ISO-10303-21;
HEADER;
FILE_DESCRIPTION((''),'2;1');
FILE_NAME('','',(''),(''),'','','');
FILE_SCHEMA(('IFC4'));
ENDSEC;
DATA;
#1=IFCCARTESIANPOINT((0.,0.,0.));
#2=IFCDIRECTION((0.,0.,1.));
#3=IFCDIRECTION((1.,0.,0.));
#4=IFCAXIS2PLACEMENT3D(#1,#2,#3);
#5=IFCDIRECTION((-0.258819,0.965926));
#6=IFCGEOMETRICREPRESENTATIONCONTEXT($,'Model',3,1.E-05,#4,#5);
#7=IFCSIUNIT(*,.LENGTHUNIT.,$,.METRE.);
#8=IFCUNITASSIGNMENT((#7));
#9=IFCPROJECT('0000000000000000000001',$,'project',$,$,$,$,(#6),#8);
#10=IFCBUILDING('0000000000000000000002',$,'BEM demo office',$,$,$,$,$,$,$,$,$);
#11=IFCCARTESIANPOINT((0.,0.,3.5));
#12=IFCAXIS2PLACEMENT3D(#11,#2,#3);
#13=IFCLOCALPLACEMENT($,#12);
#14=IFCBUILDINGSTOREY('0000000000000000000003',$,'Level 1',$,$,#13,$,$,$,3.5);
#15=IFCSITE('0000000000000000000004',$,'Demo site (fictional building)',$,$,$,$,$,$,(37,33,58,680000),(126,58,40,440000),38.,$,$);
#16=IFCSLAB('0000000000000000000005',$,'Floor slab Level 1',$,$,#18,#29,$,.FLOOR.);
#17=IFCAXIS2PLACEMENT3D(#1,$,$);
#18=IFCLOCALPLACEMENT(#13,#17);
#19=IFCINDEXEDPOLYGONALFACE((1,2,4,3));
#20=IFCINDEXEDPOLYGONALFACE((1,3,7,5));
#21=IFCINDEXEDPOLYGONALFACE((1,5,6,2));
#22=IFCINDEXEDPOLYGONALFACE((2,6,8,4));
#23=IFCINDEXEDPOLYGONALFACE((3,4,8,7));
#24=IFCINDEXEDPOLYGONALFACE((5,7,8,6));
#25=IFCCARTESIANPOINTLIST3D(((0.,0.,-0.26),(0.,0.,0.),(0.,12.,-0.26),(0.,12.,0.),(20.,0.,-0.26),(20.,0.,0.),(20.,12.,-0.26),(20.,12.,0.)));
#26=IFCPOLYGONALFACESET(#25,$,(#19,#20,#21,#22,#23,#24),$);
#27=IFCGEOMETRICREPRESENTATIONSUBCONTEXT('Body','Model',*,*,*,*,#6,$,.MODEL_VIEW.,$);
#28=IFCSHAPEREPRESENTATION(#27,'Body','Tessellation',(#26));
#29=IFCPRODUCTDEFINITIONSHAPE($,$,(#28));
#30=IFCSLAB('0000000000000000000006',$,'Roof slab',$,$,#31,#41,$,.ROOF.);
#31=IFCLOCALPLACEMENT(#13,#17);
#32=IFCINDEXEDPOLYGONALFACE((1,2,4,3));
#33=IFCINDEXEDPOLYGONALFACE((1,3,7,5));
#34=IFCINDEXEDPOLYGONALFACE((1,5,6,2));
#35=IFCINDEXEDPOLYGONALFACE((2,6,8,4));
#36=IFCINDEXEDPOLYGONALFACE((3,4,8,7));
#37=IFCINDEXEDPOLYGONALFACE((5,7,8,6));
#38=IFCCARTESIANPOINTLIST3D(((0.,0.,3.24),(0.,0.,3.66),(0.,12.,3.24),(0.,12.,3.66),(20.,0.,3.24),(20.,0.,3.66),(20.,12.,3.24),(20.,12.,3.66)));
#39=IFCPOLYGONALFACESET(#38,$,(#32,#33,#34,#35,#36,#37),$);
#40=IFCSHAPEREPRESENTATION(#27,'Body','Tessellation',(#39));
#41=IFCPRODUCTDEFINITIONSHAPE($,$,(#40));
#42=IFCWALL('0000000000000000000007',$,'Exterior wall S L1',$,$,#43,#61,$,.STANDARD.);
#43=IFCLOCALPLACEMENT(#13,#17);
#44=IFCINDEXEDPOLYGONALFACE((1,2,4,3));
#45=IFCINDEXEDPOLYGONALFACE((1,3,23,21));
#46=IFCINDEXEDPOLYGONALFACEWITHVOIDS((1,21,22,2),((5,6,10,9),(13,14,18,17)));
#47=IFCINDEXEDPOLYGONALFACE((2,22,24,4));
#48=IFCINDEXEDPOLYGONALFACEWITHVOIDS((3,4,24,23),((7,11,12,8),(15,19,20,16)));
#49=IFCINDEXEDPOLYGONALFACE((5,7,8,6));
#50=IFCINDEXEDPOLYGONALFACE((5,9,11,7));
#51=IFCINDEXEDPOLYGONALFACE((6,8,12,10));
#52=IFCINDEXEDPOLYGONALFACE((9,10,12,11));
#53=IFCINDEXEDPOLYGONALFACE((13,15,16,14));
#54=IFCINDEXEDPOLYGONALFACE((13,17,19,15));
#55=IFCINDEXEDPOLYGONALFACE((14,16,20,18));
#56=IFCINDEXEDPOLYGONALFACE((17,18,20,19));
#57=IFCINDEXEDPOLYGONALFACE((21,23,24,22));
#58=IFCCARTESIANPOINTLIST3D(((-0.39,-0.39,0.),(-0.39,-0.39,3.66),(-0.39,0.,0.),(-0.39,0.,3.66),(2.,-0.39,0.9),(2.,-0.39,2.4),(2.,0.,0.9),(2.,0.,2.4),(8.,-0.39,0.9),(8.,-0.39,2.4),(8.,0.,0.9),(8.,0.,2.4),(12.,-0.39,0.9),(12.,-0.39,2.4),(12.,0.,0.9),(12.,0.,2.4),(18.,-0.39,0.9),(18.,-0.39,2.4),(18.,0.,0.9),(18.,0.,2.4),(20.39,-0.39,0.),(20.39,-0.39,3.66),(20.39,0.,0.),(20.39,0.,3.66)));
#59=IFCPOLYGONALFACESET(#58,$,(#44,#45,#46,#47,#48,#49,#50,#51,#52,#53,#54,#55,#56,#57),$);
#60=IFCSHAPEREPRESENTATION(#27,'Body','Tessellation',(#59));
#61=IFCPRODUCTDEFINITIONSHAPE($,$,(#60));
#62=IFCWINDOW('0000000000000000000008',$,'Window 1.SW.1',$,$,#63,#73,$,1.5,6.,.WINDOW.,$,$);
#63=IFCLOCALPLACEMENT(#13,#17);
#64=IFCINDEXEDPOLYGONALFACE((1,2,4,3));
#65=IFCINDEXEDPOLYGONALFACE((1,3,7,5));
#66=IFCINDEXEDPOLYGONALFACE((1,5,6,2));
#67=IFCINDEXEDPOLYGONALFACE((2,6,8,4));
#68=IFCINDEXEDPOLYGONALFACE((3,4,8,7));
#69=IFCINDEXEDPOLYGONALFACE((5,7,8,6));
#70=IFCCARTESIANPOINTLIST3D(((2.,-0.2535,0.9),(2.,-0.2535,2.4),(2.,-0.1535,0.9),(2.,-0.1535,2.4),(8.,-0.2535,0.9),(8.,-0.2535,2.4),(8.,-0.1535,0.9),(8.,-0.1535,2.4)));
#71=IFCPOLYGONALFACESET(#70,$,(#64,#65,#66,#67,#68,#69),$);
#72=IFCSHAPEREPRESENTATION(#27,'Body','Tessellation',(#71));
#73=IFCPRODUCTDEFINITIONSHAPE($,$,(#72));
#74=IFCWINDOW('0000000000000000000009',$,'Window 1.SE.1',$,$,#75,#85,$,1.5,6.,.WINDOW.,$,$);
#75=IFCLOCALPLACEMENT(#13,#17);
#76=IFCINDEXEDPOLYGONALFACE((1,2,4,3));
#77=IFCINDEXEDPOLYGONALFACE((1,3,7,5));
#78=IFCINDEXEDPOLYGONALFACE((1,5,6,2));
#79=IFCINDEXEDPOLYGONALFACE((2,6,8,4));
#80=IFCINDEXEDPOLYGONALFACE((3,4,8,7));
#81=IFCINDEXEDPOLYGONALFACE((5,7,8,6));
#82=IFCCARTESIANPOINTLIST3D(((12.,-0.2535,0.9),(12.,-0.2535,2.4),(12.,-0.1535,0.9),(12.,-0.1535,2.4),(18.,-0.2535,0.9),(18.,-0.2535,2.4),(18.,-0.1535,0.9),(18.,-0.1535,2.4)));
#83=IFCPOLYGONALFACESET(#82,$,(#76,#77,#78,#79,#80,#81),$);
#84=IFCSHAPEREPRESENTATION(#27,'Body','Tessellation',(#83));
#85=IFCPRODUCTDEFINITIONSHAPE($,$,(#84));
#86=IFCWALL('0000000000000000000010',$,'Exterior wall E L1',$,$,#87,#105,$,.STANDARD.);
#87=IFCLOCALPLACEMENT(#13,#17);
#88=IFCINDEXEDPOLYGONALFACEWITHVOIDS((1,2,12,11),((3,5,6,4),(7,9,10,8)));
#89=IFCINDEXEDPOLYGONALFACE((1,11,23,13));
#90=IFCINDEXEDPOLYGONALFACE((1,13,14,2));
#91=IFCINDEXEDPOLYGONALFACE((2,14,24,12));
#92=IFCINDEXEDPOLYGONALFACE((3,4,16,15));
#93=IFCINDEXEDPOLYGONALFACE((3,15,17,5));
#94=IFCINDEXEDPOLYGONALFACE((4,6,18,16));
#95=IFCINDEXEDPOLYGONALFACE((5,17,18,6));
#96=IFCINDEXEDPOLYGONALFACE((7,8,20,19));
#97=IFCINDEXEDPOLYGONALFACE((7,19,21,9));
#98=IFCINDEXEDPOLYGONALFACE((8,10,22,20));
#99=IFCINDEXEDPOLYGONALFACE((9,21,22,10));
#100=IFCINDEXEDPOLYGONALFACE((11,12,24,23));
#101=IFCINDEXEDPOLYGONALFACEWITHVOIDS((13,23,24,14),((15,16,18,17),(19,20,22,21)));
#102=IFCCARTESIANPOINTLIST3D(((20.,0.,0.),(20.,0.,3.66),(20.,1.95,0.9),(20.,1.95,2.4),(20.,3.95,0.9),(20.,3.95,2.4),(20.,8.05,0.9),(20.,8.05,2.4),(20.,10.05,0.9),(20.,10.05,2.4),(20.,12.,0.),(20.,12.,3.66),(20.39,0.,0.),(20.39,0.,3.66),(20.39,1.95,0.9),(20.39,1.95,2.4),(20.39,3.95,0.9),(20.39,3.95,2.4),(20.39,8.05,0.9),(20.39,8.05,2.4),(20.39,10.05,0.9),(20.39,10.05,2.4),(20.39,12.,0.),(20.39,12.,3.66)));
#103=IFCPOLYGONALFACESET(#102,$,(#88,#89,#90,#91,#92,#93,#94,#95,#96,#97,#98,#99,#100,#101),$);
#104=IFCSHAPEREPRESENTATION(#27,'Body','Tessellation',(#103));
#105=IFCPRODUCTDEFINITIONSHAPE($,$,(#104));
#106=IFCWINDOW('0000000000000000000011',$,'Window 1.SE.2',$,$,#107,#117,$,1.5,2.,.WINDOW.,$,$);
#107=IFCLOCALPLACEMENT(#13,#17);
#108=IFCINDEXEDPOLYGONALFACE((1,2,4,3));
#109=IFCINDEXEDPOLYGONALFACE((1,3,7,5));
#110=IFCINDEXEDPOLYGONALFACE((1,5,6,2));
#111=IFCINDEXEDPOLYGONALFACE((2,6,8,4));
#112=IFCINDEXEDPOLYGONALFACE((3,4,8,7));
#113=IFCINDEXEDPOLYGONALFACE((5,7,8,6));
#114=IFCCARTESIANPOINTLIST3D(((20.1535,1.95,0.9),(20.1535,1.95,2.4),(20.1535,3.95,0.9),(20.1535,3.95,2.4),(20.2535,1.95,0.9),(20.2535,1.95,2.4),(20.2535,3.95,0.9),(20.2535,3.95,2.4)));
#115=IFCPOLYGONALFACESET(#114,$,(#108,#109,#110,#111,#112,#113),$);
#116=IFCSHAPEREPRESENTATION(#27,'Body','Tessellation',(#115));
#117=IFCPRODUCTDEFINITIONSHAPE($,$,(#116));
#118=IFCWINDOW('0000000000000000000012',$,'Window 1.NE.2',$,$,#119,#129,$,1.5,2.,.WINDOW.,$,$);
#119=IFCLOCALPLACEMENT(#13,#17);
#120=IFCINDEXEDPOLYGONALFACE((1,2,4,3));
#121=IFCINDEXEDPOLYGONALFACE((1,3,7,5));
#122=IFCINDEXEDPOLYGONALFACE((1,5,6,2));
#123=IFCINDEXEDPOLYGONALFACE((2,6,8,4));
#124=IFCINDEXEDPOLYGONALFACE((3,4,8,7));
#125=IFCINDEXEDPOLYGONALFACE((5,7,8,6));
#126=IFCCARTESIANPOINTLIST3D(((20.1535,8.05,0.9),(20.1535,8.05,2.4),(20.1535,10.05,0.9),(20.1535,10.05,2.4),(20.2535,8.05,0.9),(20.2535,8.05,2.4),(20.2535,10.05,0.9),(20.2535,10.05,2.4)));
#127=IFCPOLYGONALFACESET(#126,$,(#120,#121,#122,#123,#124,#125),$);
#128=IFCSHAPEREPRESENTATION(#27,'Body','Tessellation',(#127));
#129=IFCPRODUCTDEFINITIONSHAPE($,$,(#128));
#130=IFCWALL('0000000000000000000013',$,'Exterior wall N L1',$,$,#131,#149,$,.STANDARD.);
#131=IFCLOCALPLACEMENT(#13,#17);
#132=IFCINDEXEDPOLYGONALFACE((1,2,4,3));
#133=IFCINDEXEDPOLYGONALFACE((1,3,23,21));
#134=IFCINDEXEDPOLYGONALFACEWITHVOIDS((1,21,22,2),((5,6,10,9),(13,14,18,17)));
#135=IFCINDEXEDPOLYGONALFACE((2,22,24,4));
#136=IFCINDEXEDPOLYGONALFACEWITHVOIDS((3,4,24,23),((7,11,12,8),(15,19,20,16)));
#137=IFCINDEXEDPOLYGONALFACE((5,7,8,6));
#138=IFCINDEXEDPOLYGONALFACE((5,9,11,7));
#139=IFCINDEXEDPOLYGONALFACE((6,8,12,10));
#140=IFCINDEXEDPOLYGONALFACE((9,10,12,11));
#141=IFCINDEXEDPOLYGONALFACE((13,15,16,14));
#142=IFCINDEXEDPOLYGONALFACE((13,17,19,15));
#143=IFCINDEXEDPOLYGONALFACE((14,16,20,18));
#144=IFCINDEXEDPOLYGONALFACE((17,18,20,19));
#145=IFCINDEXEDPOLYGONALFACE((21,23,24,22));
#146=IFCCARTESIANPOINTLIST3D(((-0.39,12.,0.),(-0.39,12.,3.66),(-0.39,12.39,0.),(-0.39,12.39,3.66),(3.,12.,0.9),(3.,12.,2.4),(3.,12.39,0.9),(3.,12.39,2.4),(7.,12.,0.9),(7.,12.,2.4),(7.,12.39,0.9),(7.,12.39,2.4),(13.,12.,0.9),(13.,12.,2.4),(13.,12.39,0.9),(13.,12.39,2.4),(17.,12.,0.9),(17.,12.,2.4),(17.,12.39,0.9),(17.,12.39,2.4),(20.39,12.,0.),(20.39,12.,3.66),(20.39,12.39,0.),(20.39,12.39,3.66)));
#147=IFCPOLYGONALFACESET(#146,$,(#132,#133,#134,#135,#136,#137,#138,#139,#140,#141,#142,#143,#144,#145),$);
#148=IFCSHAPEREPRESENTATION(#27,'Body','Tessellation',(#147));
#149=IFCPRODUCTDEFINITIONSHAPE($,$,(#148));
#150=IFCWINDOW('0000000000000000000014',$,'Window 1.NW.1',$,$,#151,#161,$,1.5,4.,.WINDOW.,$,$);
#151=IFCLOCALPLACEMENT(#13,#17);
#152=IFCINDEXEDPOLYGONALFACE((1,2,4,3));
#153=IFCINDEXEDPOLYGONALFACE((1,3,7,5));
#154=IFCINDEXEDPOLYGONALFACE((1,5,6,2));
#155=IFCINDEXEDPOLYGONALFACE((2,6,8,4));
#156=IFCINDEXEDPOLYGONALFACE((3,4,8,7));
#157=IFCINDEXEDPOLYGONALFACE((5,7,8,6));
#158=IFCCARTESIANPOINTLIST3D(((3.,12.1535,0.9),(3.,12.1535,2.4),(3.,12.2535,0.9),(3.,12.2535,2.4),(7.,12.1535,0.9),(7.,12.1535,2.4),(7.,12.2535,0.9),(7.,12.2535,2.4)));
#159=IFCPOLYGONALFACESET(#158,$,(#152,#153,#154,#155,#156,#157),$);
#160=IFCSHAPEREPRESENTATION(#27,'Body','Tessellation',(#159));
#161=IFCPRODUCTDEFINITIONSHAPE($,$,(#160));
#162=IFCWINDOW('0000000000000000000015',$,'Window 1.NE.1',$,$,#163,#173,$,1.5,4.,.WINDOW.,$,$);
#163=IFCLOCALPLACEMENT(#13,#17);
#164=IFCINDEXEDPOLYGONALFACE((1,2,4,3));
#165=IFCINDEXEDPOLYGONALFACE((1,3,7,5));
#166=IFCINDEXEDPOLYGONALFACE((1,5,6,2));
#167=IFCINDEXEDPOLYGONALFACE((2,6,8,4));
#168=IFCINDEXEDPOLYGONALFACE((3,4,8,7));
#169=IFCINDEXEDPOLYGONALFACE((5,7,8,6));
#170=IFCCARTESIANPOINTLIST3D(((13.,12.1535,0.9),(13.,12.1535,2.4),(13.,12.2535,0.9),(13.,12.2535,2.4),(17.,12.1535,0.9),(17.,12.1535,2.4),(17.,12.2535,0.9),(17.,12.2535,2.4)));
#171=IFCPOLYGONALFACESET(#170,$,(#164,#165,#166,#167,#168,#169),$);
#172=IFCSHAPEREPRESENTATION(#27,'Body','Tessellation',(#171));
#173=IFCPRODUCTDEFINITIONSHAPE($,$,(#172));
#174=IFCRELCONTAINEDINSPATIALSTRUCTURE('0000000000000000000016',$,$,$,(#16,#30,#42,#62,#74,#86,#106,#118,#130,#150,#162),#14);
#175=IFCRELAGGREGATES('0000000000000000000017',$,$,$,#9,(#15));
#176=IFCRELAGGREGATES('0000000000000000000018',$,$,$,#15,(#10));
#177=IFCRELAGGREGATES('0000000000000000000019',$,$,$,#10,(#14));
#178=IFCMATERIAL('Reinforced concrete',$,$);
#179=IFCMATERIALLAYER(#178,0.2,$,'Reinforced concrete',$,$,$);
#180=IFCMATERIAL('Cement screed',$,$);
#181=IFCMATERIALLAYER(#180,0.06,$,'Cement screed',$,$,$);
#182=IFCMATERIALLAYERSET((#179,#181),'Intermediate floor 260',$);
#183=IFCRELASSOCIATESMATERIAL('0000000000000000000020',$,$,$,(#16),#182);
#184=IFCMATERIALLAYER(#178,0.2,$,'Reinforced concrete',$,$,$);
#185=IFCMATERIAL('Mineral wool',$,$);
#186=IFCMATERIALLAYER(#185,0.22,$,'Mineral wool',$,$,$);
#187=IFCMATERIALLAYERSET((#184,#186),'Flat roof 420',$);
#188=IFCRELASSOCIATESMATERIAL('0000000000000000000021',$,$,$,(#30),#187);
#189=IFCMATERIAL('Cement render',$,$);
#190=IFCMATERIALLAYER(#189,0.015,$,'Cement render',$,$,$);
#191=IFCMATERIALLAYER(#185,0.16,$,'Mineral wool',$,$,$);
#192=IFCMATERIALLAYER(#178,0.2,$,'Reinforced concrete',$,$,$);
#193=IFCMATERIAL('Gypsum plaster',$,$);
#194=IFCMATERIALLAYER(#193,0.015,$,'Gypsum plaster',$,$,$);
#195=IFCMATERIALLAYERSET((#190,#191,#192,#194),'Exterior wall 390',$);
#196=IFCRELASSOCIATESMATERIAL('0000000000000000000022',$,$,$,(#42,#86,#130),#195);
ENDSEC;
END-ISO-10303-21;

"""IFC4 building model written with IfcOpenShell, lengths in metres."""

from ifc_helpers import new_model, si_unit, direction, frame, frame_2d, origin, origin_with_axes, place, context, subcontext, project, spatial, rectangle, extrude, material, layer, layer_set, layer_usage, element, fill, save


model = new_model("IFC4")

# Units and contexts
model_context = context("Model", 3, precision=1e-05, world=origin_with_axes(), true_north=direction((-0.258819, 0.965926)))
body_context = subcontext(model_context, "Body", "Model", "MODEL_VIEW")
ifc_project = project(units=[si_unit("LENGTHUNIT", "METRE")], contexts=[model_context])

# Site, building, storey
site = spatial("IfcSite", under=ifc_project, Name="Demo site (fictional building)", RefLatitude=(37, 33, 58, 680000), RefLongitude=(126, 58, 40, 440000), RefElevation=38.0)
building = spatial("IfcBuilding", under=site, Name="BEM demo office")
storey_placement = place(None, frame((0.0, 0.0, 3.5), z_axis=(0.0, 0.0, 1.0), x_axis=(1.0, 0.0, 0.0)))
storey = spatial("IfcBuildingStorey", under=building, at=storey_placement, Name="Level 1", Elevation=3.5)

# Slabs
ifc_material_1 = material(Name="Reinforced concrete")
ifc_layer_1 = layer(ifc_material_1, 0.2, Name="Reinforced concrete")
ifc_material_2 = material(Name="Cement screed")
ifc_layer_2 = layer(ifc_material_2, 0.06, Name="Cement screed")
ifc_layer_set_1 = layer_set([ifc_layer_1, ifc_layer_2], Name="Intermediate floor 260")
ifc_layer_usage_1 = layer_usage(ifc_layer_set_1, "AXIS3", "POSITIVE", 0.0)
slab_1_placement = place(storey_placement, frame((0.0, 0.0, -0.26), z_axis=(0.0, 0.0, 1.0), x_axis=(1.0, 0.0, 0.0)))
element("IfcSlab", 1, at=slab_1_placement, inside=storey, material=ifc_layer_usage_1, Name="Floor slab Level 1", PredefinedType="FLOOR", context=body_context, shape_type="SweptSolid", body=[
    extrude(rectangle(XDim=20.0, YDim=12.0, at=frame_2d((10.0, 6.0))), origin(), (0.0, 0.0, 1.0), 0.26),
])
ifc_layer_3 = layer(ifc_material_1, 0.2, Name="Reinforced concrete")
ifc_material_3 = material(Name="Mineral wool")
ifc_layer_4 = layer(ifc_material_3, 0.22, Name="Mineral wool")
ifc_layer_set_2 = layer_set([ifc_layer_3, ifc_layer_4], Name="Flat roof 420")
ifc_layer_usage_2 = layer_usage(ifc_layer_set_2, "AXIS3", "POSITIVE", 0.0)
slab_2_placement = place(storey_placement, frame((0.0, 0.0, 3.24), z_axis=(0.0, 0.0, 1.0), x_axis=(1.0, 0.0, 0.0)))
element("IfcSlab", 2, at=slab_2_placement, inside=storey, material=ifc_layer_usage_2, Name="Roof slab", PredefinedType="ROOF", context=body_context, shape_type="SweptSolid", body=[
    extrude(rectangle(XDim=20.0, YDim=12.0, at=frame_2d((10.0, 6.0))), origin(), (0.0, 0.0, 1.0), 0.42),
])

# Walls, openings, windows
ifc_material_4 = material(Name="Cement render")
ifc_layer_5 = layer(ifc_material_4, 0.015, Name="Cement render")
ifc_layer_6 = layer(ifc_material_3, 0.16, Name="Mineral wool")
ifc_layer_7 = layer(ifc_material_1, 0.2, Name="Reinforced concrete")
ifc_material_5 = material(Name="Gypsum plaster")
ifc_layer_8 = layer(ifc_material_5, 0.015, Name="Gypsum plaster")
ifc_layer_set_3 = layer_set([ifc_layer_5, ifc_layer_6, ifc_layer_7, ifc_layer_8], Name="Exterior wall 390")
ifc_layer_usage_3 = layer_usage(ifc_layer_set_3, "AXIS2", "POSITIVE", 0.0)
wall_1_placement = place(storey_placement, frame((-0.39, -0.39, 0.0), z_axis=(0.0, 0.0, 1.0), x_axis=(1.0, 0.0, 0.0)))
wall_1 = element("IfcWall", 3, at=wall_1_placement, inside=storey, material=ifc_layer_usage_3, Name="Exterior wall S L1", PredefinedType="STANDARD", context=body_context, shape_type="SweptSolid", body=[
    extrude(rectangle(XDim=20.78, YDim=0.39, at=frame_2d((10.39, 0.195))), origin(), (0.0, 0.0, 1.0), 3.66),
])
opening_1_placement = place(wall_1_placement, origin())
opening_1 = element("IfcOpeningElement", 4, at=opening_1_placement, cuts=wall_1, PredefinedType="OPENING", context=body_context, shape_type="SweptSolid", body=[
    extrude(rectangle(XDim=6.0, YDim=0.49, at=frame_2d((3.0, 0.245))), frame((2.39, -0.05, 0.9)), (0.0, 0.0, 1.0), 1.5),
])
opening_2_placement = place(wall_1_placement, origin())
opening_2 = element("IfcOpeningElement", 5, at=opening_2_placement, cuts=wall_1, PredefinedType="OPENING", context=body_context, shape_type="SweptSolid", body=[
    extrude(rectangle(XDim=6.0, YDim=0.49, at=frame_2d((3.0, 0.245))), frame((12.39, -0.05, 0.9)), (0.0, 0.0, 1.0), 1.5),
])
window_1_placement = place(opening_1_placement, origin_with_axes())
window_1 = element("IfcWindow", 6, at=window_1_placement, inside=storey, Name="Window 1.SW.1", OverallHeight=1.5, OverallWidth=6.0, PredefinedType="WINDOW", context=body_context, shape_type="SweptSolid", body=[
    extrude(rectangle(XDim=6.0, YDim=0.1, at=frame_2d((3.0, 0.05))), frame((2.39, 0.1365, 0.9)), (0.0, 0.0, 1.0), 1.5),
])
fill(opening_1, window_1)
window_2_placement = place(opening_2_placement, origin_with_axes())
window_2 = element("IfcWindow", 7, at=window_2_placement, inside=storey, Name="Window 1.SE.1", OverallHeight=1.5, OverallWidth=6.0, PredefinedType="WINDOW", context=body_context, shape_type="SweptSolid", body=[
    extrude(rectangle(XDim=6.0, YDim=0.1, at=frame_2d((3.0, 0.05))), frame((12.39, 0.1365, 0.9)), (0.0, 0.0, 1.0), 1.5),
])
fill(opening_2, window_2)
wall_2_placement = place(storey_placement, frame((20.39, 0.0, 0.0), z_axis=(0.0, 0.0, 1.0), x_axis=(0.0, 1.0, 0.0)))
wall_2 = element("IfcWall", 8, at=wall_2_placement, inside=storey, material=ifc_layer_usage_3, Name="Exterior wall E L1", PredefinedType="STANDARD", context=body_context, shape_type="SweptSolid", body=[
    extrude(rectangle(XDim=12.0, YDim=0.39, at=frame_2d((6.0, 0.195))), origin(), (0.0, 0.0, 1.0), 3.66),
])
opening_3_placement = place(wall_2_placement, origin())
opening_3 = element("IfcOpeningElement", 9, at=opening_3_placement, cuts=wall_2, PredefinedType="OPENING", context=body_context, shape_type="SweptSolid", body=[
    extrude(rectangle(XDim=2.0, YDim=0.49, at=frame_2d((1.0, 0.245))), frame((1.95, -0.05, 0.9)), (0.0, 0.0, 1.0), 1.5),
])
opening_4_placement = place(wall_2_placement, origin())
opening_4 = element("IfcOpeningElement", 10, at=opening_4_placement, cuts=wall_2, PredefinedType="OPENING", context=body_context, shape_type="SweptSolid", body=[
    extrude(rectangle(XDim=2.0, YDim=0.49, at=frame_2d((1.0, 0.245))), frame((8.05, -0.05, 0.9)), (0.0, 0.0, 1.0), 1.5),
])
window_3_placement = place(opening_3_placement, origin_with_axes())
window_3 = element("IfcWindow", 11, at=window_3_placement, inside=storey, Name="Window 1.SE.2", OverallHeight=1.5, OverallWidth=2.0, PredefinedType="WINDOW", context=body_context, shape_type="SweptSolid", body=[
    extrude(rectangle(XDim=2.0, YDim=0.1, at=frame_2d((1.0, 0.05))), frame((1.95, 0.1365, 0.9)), (0.0, 0.0, 1.0), 1.5),
])
fill(opening_3, window_3)
window_4_placement = place(opening_4_placement, origin_with_axes())
window_4 = element("IfcWindow", 12, at=window_4_placement, inside=storey, Name="Window 1.NE.2", OverallHeight=1.5, OverallWidth=2.0, PredefinedType="WINDOW", context=body_context, shape_type="SweptSolid", body=[
    extrude(rectangle(XDim=2.0, YDim=0.1, at=frame_2d((1.0, 0.05))), frame((8.05, 0.1365, 0.9)), (0.0, 0.0, 1.0), 1.5),
])
fill(opening_4, window_4)
wall_3_placement = place(storey_placement, frame((20.39, 12.39, 0.0), z_axis=(0.0, 0.0, 1.0), x_axis=(-1.0, 0.0, 0.0)))
wall_3 = element("IfcWall", 13, at=wall_3_placement, inside=storey, material=ifc_layer_usage_3, Name="Exterior wall N L1", PredefinedType="STANDARD", context=body_context, shape_type="SweptSolid", body=[
    extrude(rectangle(XDim=20.78, YDim=0.39, at=frame_2d((10.39, 0.195))), origin(), (0.0, 0.0, 1.0), 3.66),
])
opening_5_placement = place(wall_3_placement, origin())
opening_5 = element("IfcOpeningElement", 14, at=opening_5_placement, cuts=wall_3, PredefinedType="OPENING", context=body_context, shape_type="SweptSolid", body=[
    extrude(rectangle(XDim=4.0, YDim=0.49, at=frame_2d((2.0, 0.245))), frame((13.39, -0.05, 0.9)), (0.0, 0.0, 1.0), 1.5),
])
opening_6_placement = place(wall_3_placement, origin())
opening_6 = element("IfcOpeningElement", 15, at=opening_6_placement, cuts=wall_3, PredefinedType="OPENING", context=body_context, shape_type="SweptSolid", body=[
    extrude(rectangle(XDim=4.0, YDim=0.49, at=frame_2d((2.0, 0.245))), frame((3.39, -0.05, 0.9)), (0.0, 0.0, 1.0), 1.5),
])
window_5_placement = place(opening_5_placement, origin_with_axes())
window_5 = element("IfcWindow", 16, at=window_5_placement, inside=storey, Name="Window 1.NW.1", OverallHeight=1.5, OverallWidth=4.0, PredefinedType="WINDOW", context=body_context, shape_type="SweptSolid", body=[
    extrude(rectangle(XDim=4.0, YDim=0.1, at=frame_2d((2.0, 0.05))), frame((13.39, 0.1365, 0.9)), (0.0, 0.0, 1.0), 1.5),
])
fill(opening_5, window_5)
window_6_placement = place(opening_6_placement, origin_with_axes())
window_6 = element("IfcWindow", 17, at=window_6_placement, inside=storey, Name="Window 1.NE.1", OverallHeight=1.5, OverallWidth=4.0, PredefinedType="WINDOW", context=body_context, shape_type="SweptSolid", body=[
    extrude(rectangle(XDim=4.0, YDim=0.1, at=frame_2d((2.0, 0.05))), frame((3.39, 0.1365, 0.9)), (0.0, 0.0, 1.0), 1.5),
])
fill(opening_6, window_6)

save(model, "model.ifc")
